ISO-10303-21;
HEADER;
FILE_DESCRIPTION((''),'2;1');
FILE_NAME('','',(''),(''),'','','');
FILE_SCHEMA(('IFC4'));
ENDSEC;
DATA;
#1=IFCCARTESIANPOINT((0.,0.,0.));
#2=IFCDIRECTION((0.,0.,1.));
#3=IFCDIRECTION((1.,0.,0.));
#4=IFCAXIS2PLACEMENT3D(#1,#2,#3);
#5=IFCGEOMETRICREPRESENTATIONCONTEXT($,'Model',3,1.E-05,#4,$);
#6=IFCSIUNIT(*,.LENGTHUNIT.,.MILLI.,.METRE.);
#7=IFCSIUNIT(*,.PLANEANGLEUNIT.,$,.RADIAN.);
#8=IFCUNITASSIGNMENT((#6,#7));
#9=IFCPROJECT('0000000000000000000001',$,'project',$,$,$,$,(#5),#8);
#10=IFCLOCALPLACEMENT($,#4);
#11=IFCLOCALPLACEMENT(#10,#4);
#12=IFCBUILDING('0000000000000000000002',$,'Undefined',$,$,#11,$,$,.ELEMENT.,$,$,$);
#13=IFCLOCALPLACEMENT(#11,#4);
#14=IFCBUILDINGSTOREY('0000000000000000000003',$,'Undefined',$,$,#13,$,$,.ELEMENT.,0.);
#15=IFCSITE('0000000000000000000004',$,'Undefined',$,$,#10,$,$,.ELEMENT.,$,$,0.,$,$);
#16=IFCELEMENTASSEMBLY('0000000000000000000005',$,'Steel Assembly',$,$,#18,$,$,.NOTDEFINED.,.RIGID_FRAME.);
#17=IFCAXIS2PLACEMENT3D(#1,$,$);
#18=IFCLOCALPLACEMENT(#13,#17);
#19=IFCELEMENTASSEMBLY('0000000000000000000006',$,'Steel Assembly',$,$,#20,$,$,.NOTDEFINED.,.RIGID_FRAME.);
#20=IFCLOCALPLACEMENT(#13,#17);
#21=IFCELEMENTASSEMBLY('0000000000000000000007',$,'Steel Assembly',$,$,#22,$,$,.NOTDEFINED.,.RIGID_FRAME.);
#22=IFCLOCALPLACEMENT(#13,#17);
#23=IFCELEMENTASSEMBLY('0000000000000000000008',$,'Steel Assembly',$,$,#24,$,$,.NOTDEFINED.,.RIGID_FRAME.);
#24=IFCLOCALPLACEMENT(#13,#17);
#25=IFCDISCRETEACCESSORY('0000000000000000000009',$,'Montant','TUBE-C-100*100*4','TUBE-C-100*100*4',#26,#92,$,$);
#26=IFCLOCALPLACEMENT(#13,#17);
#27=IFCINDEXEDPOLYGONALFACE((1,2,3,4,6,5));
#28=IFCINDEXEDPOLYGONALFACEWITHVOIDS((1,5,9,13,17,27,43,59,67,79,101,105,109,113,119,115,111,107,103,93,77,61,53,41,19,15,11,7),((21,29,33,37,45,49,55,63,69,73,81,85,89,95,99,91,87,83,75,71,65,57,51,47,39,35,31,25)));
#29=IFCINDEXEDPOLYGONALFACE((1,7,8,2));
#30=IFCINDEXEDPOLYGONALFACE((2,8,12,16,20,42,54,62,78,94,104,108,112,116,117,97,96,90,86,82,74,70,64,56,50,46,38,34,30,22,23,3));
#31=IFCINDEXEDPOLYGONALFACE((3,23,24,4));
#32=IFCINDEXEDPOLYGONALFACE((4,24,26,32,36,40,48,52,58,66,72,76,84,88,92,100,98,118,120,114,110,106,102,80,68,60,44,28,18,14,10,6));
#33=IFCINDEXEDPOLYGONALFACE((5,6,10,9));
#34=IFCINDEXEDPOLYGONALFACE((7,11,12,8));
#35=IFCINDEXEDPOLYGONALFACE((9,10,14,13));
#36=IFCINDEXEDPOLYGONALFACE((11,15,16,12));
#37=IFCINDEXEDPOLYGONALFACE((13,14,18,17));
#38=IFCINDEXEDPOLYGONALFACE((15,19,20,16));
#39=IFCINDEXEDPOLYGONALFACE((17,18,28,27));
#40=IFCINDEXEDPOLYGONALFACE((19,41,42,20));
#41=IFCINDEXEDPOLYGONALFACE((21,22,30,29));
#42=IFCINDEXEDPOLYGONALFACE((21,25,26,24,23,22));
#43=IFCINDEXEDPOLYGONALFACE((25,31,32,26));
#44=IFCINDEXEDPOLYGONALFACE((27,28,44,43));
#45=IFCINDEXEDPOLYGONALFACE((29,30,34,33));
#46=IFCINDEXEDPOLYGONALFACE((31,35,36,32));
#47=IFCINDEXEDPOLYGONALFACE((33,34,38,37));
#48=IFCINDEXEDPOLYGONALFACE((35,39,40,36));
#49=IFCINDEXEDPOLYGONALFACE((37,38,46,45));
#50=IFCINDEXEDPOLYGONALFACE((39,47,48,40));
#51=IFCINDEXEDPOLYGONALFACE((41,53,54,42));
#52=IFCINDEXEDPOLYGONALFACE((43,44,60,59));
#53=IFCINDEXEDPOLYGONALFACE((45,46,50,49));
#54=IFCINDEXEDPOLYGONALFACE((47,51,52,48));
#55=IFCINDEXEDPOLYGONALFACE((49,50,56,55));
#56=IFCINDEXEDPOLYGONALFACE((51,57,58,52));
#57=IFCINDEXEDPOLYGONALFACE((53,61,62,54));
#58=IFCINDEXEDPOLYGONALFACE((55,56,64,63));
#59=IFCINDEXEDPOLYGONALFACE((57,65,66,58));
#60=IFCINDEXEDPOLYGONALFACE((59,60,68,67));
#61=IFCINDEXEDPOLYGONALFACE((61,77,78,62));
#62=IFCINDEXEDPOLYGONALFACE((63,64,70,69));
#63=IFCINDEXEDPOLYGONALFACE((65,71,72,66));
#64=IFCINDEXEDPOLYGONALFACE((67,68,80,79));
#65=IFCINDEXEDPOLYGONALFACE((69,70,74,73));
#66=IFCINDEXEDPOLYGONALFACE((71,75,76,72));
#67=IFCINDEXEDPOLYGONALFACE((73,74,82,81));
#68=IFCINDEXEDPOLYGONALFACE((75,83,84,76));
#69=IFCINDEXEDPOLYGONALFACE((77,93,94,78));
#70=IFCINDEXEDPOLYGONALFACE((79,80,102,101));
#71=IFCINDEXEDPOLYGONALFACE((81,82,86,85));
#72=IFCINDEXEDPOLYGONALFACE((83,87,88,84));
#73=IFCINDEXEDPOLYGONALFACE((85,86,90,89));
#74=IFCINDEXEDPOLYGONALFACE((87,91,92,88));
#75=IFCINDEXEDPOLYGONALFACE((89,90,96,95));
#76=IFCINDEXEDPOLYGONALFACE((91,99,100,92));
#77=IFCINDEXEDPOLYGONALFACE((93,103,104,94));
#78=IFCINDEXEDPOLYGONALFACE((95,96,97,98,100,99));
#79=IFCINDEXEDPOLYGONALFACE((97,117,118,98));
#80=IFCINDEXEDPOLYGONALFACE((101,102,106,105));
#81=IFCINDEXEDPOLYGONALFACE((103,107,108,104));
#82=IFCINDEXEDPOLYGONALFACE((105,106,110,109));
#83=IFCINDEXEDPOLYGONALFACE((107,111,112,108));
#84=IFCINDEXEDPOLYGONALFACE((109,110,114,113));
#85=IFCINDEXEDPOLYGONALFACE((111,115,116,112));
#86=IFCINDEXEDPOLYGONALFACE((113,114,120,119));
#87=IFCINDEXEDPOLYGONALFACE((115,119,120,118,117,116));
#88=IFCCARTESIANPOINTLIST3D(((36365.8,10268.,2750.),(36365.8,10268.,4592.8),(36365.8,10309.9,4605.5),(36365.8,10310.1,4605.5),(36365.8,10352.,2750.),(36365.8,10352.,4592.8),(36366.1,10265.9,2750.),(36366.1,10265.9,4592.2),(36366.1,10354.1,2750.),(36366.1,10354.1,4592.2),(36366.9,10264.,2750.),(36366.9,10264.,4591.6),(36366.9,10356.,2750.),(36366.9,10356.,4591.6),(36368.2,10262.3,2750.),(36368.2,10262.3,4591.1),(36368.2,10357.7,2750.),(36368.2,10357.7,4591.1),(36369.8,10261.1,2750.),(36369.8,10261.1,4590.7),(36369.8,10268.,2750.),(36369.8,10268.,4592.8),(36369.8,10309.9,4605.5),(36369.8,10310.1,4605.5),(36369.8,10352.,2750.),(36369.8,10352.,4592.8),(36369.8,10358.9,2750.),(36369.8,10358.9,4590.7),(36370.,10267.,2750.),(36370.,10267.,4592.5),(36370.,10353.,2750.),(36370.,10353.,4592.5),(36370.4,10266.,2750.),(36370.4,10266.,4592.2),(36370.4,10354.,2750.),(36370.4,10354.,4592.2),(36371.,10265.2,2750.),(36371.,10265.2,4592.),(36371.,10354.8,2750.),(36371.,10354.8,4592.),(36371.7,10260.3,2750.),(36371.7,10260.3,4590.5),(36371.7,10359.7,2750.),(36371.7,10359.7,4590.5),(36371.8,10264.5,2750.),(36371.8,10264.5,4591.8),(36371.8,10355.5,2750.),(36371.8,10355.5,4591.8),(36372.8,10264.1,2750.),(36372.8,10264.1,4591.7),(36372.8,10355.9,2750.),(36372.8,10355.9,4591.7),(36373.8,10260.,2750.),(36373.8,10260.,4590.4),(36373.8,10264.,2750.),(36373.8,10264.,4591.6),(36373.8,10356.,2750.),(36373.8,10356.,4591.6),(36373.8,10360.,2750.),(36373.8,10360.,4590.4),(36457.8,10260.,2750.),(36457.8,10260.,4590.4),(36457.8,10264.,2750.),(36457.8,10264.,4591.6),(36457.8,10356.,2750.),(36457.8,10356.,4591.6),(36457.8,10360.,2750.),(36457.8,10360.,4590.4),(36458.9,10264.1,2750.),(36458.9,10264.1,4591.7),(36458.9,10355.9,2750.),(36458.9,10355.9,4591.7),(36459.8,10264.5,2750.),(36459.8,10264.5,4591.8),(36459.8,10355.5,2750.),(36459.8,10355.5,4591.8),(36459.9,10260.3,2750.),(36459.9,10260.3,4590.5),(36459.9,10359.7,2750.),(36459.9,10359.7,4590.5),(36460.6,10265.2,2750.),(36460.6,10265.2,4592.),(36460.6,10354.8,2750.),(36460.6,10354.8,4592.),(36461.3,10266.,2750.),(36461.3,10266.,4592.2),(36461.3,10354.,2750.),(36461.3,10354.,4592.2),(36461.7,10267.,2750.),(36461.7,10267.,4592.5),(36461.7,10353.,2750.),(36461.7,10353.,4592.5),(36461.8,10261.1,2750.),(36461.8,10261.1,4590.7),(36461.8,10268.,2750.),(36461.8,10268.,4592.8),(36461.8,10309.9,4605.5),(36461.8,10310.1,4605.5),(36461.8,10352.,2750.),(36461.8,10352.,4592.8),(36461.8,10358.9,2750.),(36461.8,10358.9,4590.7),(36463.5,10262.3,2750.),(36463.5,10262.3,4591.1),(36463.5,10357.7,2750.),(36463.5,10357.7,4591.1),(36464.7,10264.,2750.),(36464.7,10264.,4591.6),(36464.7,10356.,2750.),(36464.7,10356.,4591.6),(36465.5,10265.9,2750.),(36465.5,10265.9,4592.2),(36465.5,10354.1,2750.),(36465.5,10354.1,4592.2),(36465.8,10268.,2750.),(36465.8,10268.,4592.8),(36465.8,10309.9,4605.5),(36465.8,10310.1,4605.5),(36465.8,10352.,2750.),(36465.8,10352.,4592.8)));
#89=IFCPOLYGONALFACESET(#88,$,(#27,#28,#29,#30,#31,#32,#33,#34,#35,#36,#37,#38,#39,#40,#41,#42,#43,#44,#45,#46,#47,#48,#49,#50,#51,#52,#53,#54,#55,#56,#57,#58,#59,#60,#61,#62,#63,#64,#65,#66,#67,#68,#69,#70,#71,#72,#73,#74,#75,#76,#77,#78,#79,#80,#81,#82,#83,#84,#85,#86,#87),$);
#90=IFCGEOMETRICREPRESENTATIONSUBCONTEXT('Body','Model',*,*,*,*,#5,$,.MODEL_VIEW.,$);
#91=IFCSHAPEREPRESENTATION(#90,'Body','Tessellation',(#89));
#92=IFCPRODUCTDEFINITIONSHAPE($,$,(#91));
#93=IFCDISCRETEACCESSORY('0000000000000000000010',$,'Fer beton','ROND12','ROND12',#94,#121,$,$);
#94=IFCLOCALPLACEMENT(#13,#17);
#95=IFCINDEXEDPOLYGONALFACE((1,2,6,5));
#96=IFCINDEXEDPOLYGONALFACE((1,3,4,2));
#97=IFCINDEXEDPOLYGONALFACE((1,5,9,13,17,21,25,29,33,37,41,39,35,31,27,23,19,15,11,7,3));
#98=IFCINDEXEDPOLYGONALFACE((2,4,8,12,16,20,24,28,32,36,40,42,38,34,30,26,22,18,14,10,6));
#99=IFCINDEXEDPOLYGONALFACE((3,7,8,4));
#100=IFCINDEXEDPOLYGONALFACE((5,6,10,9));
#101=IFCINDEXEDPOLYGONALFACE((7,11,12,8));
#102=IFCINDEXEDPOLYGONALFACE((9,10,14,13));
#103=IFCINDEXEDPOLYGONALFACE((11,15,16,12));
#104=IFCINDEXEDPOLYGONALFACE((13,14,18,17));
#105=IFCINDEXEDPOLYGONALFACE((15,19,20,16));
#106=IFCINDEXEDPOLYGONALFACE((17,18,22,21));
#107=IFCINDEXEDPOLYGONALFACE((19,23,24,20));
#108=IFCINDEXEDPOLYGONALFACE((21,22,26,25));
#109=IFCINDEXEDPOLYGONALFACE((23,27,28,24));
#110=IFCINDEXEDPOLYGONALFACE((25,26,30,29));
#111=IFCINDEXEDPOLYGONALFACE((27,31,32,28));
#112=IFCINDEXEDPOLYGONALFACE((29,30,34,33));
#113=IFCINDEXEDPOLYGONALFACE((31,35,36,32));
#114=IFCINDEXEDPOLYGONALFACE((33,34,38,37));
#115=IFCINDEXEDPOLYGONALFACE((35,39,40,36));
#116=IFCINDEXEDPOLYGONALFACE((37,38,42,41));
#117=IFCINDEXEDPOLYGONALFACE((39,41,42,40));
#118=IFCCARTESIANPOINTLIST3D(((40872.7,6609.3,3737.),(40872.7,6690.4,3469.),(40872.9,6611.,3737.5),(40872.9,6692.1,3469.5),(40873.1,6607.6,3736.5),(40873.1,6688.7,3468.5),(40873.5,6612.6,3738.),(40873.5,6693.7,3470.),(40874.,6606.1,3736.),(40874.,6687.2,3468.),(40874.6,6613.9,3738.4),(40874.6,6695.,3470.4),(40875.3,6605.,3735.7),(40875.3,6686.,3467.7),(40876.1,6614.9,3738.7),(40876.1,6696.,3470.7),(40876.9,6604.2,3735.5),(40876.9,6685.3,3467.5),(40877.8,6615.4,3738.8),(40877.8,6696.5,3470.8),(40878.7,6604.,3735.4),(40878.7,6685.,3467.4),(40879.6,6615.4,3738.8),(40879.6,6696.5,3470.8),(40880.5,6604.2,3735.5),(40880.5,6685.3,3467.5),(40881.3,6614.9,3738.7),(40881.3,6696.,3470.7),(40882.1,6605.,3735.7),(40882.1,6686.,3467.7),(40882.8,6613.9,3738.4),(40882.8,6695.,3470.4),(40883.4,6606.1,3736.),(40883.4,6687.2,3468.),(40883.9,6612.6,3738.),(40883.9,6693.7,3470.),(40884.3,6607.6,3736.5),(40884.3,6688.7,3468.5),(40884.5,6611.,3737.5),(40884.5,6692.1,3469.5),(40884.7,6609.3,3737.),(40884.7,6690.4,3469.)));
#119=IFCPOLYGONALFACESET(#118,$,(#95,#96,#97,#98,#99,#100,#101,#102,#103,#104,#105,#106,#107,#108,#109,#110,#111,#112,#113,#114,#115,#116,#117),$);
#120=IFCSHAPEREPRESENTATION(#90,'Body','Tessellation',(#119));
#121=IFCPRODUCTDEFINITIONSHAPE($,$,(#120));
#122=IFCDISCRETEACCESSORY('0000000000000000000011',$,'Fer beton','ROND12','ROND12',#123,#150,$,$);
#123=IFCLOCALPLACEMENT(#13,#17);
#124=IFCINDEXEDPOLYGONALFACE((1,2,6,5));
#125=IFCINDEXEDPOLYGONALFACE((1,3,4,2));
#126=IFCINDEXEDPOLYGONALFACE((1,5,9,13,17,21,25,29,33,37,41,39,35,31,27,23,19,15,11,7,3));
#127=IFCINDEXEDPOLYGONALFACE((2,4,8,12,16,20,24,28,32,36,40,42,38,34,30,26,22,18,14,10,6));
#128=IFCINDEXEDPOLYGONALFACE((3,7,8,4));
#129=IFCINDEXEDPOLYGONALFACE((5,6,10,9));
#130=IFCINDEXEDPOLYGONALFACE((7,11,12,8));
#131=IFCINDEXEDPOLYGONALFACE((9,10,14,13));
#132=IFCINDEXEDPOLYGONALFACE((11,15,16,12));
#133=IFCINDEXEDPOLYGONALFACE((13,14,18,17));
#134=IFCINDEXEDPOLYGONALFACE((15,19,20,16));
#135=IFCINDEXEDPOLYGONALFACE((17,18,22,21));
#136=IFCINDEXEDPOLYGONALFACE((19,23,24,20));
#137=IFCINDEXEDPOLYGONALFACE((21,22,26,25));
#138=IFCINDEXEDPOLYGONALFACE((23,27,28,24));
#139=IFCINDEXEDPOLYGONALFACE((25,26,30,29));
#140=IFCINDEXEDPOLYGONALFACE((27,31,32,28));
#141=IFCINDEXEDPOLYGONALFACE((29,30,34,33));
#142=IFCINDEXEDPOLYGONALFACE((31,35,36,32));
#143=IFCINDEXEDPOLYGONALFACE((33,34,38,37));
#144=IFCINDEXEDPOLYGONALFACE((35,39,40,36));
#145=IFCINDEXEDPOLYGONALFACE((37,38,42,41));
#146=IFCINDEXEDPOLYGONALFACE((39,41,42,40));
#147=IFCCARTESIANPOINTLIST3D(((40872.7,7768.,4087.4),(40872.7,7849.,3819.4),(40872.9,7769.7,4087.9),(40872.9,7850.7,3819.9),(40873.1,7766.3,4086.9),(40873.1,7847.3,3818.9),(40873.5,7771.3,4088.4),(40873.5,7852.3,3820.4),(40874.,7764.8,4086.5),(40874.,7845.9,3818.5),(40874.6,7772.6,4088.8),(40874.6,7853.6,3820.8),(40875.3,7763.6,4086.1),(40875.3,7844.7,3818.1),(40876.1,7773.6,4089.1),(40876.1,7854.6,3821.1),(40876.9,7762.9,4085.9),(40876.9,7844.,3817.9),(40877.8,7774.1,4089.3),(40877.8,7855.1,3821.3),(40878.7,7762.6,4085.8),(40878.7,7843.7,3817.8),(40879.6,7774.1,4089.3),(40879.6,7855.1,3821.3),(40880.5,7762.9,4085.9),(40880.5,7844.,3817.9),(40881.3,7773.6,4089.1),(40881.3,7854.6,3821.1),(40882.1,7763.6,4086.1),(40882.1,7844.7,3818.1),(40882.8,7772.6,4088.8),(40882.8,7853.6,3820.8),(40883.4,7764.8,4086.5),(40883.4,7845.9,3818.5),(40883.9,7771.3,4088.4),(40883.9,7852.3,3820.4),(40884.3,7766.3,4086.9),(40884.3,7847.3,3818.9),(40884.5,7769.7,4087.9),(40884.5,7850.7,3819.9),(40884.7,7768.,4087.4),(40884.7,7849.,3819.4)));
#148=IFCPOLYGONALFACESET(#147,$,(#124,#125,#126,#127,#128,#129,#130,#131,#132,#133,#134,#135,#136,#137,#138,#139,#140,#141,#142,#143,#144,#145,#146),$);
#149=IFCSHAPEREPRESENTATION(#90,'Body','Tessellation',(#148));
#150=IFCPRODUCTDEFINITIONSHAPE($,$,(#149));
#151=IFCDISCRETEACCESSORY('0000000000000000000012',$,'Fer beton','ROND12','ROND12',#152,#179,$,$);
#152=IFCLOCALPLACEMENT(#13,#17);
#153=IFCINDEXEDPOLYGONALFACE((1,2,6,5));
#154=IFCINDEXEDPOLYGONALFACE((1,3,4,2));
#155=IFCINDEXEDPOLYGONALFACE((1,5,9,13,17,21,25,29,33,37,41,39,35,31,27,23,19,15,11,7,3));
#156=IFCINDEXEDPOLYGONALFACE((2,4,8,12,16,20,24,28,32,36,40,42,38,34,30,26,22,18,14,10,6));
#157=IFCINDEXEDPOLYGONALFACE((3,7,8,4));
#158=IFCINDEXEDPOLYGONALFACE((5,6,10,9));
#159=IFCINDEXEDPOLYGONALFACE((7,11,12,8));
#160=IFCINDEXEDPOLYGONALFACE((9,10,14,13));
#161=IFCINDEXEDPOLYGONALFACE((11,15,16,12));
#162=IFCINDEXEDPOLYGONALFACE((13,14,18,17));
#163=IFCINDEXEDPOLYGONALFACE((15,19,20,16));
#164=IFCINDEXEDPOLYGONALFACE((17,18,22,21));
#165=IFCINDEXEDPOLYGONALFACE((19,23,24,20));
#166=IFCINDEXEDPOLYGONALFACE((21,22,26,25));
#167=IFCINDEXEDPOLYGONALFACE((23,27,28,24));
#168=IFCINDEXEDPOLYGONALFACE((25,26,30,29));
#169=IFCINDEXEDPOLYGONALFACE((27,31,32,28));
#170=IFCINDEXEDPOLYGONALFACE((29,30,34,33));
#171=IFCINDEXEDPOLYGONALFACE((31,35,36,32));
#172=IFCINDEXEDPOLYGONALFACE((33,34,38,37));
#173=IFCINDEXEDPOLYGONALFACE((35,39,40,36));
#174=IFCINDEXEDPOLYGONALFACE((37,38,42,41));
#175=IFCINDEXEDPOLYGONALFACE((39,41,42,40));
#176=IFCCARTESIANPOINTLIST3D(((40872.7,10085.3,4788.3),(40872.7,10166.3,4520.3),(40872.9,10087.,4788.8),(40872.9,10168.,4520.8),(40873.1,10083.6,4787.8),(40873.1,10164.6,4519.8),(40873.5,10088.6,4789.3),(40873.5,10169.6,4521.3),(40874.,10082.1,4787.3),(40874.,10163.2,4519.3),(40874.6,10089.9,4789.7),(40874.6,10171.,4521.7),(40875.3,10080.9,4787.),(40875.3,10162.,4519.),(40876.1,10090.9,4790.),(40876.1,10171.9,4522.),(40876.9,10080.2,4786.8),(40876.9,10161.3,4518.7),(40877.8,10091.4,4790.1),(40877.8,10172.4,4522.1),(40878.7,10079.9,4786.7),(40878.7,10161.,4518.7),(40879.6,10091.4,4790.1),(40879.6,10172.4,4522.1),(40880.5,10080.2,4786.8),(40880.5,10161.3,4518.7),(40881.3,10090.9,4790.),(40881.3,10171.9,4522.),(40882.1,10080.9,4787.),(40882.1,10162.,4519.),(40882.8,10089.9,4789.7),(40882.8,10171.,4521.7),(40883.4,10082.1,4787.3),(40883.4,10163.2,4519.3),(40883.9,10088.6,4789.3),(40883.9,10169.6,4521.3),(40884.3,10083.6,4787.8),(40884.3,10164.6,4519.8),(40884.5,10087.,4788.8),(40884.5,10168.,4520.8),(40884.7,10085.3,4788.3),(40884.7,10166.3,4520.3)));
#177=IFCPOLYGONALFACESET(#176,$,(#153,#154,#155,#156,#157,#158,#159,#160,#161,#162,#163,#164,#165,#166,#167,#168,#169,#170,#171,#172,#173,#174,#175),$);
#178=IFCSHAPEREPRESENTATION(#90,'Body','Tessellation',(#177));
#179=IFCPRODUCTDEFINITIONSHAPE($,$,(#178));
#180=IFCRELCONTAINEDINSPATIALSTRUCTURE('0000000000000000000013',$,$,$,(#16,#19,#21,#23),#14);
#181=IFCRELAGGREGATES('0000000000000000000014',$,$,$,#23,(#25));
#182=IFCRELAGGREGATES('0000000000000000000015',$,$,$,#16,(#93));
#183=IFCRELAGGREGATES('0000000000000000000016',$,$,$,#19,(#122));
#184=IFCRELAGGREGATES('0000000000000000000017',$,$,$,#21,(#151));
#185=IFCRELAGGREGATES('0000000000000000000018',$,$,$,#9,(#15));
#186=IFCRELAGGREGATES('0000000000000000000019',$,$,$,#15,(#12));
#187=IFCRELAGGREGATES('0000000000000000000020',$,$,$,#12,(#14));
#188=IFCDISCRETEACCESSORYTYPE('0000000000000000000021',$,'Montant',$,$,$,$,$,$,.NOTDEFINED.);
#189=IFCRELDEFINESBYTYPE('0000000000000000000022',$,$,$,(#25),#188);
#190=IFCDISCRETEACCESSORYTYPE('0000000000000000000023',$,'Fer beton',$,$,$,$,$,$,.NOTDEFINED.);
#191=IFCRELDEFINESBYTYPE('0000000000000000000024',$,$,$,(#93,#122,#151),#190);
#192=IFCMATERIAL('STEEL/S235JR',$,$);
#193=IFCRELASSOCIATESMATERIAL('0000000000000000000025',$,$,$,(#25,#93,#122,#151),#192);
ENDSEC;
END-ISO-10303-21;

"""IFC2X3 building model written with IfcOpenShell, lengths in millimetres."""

from ifc_helpers import new_model, si_unit, frame, origin_with_axes, origin_2d_with_axis, place, context, subcontext, project, spatial, hollow_rectangle, circle, extrude, clip, halfspace, material, type_object, element, aggregate, save


model = new_model("IFC2X3")

# Units and contexts
model_context = context("Model", 3, precision=1e-05, world=origin_with_axes())
body_context = subcontext(model_context, "Body", "Model", "MODEL_VIEW")
ifc_project = project(units=[si_unit("LENGTHUNIT", "METRE", prefix="MILLI"), si_unit("PLANEANGLEUNIT", "RADIAN")], contexts=[model_context])

# Site, building, storey
site_placement = place(None, origin_with_axes())
site = spatial("IfcSite", under=ifc_project, at=site_placement, Name="Undefined", CompositionType="ELEMENT", RefElevation=0.0)
building_placement = place(site_placement, origin_with_axes())
building = spatial("IfcBuilding", under=site, at=building_placement, Name="Undefined", CompositionType="ELEMENT")
storey_placement = place(building_placement, origin_with_axes())
storey = spatial("IfcBuildingStorey", under=building, at=storey_placement, Name="Undefined", CompositionType="ELEMENT", Elevation=0.0)

# Element assemblies
assembly_1_placement = place(storey_placement, origin_with_axes())
assembly_1 = element("IfcElementAssembly", 1, at=assembly_1_placement, inside=storey, Name="Steel Assembly", AssemblyPlace="NOTDEFINED", PredefinedType="RIGID_FRAME")
ifc_material_1 = material(Name="STEEL/S235JR")
assembly_2_placement = place(storey_placement, origin_with_axes())
assembly_2 = element("IfcElementAssembly", 2, at=assembly_2_placement, inside=storey, Name="Steel Assembly", AssemblyPlace="NOTDEFINED", PredefinedType="RIGID_FRAME")
assembly_3_placement = place(storey_placement, origin_with_axes())
assembly_3 = element("IfcElementAssembly", 3, at=assembly_3_placement, inside=storey, Name="Steel Assembly", AssemblyPlace="NOTDEFINED", PredefinedType="RIGID_FRAME")

# Element assembly, discrete accessory
assembly_4_placement = place(storey_placement, origin_with_axes())
assembly_4 = element("IfcElementAssembly", 4, at=assembly_4_placement, inside=storey, Name="Steel Assembly", AssemblyPlace="NOTDEFINED", PredefinedType="RIGID_FRAME")
discrete_accessory_type_1 = type_object("IfcDiscreteAccessoryType", Name="Montant")
discrete_accessory_1_placement = place(assembly_4_placement, frame((36415.8, 10310.0, 4605.5), z_axis=(-1.0, 0.0, 0.0), x_axis=(0.0, 0.0, -1.0)))
discrete_accessory_1 = element("IfcDiscreteAccessory", 5, at=discrete_accessory_1_placement, type_object=discrete_accessory_type_1, material=ifc_material_1, Name="Montant", Description="TUBE-C-100*100*4", ObjectType="TUBE-C-100*100*4", context=body_context, shape_type="Clipping", body=[
    clip(clip(extrude(hollow_rectangle(XDim=100.0, YDim=100.0, WallThickness=4.0, InnerFilletRadius=4.0, OuterFilletRadius=8.0, at=origin_2d_with_axis()), frame((1855.5, 0.0, 0.0), z_axis=(-1.0, 0.0, 0.0), x_axis=(0.0, -1.0, 0.0)), (0.0, 0.0, 1.0), 1855.5), halfspace(frame((-15.1, -50.0, -50.0), z_axis=(-0.957179, 0.289497, 0.0), x_axis=(0.289497, 0.957179, 0.0)), False)), halfspace(frame((-15.1, 50.0, -50.0), z_axis=(-0.957179, -0.289497, 0.0), x_axis=(0.0, 0.0, 1.0)), False)),
])
aggregate(assembly_4, [discrete_accessory_1])

# Discrete accessories
discrete_accessory_type_2 = type_object("IfcDiscreteAccessoryType", Name="Fer beton")
discrete_accessory_2_placement = place(assembly_1_placement, frame((40878.7, 6609.7, 3737.1), z_axis=(1.0, 0.0, 0.0), x_axis=(0.0, 0.289497, -0.957179)))
discrete_accessory_2 = element("IfcDiscreteAccessory", 6, at=discrete_accessory_2_placement, type_object=discrete_accessory_type_2, material=ifc_material_1, Name="Fer beton", Description="ROND12", ObjectType="ROND12", context=body_context, shape_type="SweptSolid", body=[
    extrude(circle(Radius=6.0, at=origin_2d_with_axis()), frame((280.0, 0.0, 0.0), z_axis=(-1.0, 0.0, 0.0), x_axis=(0.0, -1.0, 0.0)), (0.0, 0.0, 1.0), 280.0),
])
aggregate(assembly_1, [discrete_accessory_2])
discrete_accessory_3_placement = place(assembly_2_placement, frame((40878.7, 7768.4, 4087.6), z_axis=(1.0, 0.0, 0.0), x_axis=(0.0, 0.289497, -0.957179)))
discrete_accessory_3 = element("IfcDiscreteAccessory", 7, at=discrete_accessory_3_placement, type_object=discrete_accessory_type_2, material=ifc_material_1, Name="Fer beton", Description="ROND12", ObjectType="ROND12", context=body_context, shape_type="SweptSolid", body=[
    extrude(circle(Radius=6.0, at=origin_2d_with_axis()), frame((280.0, 0.0, 0.0), z_axis=(-1.0, 0.0, 0.0), x_axis=(0.0, -1.0, 0.0)), (0.0, 0.0, 1.0), 280.0),
])
aggregate(assembly_2, [discrete_accessory_3])
discrete_accessory_4_placement = place(assembly_3_placement, frame((40878.7, 10085.7, 4788.4), z_axis=(1.0, 0.0, 0.0), x_axis=(0.0, 0.289497, -0.957179)))
discrete_accessory_4 = element("IfcDiscreteAccessory", 8, at=discrete_accessory_4_placement, type_object=discrete_accessory_type_2, material=ifc_material_1, Name="Fer beton", Description="ROND12", ObjectType="ROND12", context=body_context, shape_type="SweptSolid", body=[
    extrude(circle(Radius=6.0, at=origin_2d_with_axis()), frame((280.0, 0.0, 0.0), z_axis=(-1.0, 0.0, 0.0), x_axis=(0.0, -1.0, 0.0)), (0.0, 0.0, 1.0), 280.0),
])
aggregate(assembly_3, [discrete_accessory_4])

save(model, "model.ifc")
